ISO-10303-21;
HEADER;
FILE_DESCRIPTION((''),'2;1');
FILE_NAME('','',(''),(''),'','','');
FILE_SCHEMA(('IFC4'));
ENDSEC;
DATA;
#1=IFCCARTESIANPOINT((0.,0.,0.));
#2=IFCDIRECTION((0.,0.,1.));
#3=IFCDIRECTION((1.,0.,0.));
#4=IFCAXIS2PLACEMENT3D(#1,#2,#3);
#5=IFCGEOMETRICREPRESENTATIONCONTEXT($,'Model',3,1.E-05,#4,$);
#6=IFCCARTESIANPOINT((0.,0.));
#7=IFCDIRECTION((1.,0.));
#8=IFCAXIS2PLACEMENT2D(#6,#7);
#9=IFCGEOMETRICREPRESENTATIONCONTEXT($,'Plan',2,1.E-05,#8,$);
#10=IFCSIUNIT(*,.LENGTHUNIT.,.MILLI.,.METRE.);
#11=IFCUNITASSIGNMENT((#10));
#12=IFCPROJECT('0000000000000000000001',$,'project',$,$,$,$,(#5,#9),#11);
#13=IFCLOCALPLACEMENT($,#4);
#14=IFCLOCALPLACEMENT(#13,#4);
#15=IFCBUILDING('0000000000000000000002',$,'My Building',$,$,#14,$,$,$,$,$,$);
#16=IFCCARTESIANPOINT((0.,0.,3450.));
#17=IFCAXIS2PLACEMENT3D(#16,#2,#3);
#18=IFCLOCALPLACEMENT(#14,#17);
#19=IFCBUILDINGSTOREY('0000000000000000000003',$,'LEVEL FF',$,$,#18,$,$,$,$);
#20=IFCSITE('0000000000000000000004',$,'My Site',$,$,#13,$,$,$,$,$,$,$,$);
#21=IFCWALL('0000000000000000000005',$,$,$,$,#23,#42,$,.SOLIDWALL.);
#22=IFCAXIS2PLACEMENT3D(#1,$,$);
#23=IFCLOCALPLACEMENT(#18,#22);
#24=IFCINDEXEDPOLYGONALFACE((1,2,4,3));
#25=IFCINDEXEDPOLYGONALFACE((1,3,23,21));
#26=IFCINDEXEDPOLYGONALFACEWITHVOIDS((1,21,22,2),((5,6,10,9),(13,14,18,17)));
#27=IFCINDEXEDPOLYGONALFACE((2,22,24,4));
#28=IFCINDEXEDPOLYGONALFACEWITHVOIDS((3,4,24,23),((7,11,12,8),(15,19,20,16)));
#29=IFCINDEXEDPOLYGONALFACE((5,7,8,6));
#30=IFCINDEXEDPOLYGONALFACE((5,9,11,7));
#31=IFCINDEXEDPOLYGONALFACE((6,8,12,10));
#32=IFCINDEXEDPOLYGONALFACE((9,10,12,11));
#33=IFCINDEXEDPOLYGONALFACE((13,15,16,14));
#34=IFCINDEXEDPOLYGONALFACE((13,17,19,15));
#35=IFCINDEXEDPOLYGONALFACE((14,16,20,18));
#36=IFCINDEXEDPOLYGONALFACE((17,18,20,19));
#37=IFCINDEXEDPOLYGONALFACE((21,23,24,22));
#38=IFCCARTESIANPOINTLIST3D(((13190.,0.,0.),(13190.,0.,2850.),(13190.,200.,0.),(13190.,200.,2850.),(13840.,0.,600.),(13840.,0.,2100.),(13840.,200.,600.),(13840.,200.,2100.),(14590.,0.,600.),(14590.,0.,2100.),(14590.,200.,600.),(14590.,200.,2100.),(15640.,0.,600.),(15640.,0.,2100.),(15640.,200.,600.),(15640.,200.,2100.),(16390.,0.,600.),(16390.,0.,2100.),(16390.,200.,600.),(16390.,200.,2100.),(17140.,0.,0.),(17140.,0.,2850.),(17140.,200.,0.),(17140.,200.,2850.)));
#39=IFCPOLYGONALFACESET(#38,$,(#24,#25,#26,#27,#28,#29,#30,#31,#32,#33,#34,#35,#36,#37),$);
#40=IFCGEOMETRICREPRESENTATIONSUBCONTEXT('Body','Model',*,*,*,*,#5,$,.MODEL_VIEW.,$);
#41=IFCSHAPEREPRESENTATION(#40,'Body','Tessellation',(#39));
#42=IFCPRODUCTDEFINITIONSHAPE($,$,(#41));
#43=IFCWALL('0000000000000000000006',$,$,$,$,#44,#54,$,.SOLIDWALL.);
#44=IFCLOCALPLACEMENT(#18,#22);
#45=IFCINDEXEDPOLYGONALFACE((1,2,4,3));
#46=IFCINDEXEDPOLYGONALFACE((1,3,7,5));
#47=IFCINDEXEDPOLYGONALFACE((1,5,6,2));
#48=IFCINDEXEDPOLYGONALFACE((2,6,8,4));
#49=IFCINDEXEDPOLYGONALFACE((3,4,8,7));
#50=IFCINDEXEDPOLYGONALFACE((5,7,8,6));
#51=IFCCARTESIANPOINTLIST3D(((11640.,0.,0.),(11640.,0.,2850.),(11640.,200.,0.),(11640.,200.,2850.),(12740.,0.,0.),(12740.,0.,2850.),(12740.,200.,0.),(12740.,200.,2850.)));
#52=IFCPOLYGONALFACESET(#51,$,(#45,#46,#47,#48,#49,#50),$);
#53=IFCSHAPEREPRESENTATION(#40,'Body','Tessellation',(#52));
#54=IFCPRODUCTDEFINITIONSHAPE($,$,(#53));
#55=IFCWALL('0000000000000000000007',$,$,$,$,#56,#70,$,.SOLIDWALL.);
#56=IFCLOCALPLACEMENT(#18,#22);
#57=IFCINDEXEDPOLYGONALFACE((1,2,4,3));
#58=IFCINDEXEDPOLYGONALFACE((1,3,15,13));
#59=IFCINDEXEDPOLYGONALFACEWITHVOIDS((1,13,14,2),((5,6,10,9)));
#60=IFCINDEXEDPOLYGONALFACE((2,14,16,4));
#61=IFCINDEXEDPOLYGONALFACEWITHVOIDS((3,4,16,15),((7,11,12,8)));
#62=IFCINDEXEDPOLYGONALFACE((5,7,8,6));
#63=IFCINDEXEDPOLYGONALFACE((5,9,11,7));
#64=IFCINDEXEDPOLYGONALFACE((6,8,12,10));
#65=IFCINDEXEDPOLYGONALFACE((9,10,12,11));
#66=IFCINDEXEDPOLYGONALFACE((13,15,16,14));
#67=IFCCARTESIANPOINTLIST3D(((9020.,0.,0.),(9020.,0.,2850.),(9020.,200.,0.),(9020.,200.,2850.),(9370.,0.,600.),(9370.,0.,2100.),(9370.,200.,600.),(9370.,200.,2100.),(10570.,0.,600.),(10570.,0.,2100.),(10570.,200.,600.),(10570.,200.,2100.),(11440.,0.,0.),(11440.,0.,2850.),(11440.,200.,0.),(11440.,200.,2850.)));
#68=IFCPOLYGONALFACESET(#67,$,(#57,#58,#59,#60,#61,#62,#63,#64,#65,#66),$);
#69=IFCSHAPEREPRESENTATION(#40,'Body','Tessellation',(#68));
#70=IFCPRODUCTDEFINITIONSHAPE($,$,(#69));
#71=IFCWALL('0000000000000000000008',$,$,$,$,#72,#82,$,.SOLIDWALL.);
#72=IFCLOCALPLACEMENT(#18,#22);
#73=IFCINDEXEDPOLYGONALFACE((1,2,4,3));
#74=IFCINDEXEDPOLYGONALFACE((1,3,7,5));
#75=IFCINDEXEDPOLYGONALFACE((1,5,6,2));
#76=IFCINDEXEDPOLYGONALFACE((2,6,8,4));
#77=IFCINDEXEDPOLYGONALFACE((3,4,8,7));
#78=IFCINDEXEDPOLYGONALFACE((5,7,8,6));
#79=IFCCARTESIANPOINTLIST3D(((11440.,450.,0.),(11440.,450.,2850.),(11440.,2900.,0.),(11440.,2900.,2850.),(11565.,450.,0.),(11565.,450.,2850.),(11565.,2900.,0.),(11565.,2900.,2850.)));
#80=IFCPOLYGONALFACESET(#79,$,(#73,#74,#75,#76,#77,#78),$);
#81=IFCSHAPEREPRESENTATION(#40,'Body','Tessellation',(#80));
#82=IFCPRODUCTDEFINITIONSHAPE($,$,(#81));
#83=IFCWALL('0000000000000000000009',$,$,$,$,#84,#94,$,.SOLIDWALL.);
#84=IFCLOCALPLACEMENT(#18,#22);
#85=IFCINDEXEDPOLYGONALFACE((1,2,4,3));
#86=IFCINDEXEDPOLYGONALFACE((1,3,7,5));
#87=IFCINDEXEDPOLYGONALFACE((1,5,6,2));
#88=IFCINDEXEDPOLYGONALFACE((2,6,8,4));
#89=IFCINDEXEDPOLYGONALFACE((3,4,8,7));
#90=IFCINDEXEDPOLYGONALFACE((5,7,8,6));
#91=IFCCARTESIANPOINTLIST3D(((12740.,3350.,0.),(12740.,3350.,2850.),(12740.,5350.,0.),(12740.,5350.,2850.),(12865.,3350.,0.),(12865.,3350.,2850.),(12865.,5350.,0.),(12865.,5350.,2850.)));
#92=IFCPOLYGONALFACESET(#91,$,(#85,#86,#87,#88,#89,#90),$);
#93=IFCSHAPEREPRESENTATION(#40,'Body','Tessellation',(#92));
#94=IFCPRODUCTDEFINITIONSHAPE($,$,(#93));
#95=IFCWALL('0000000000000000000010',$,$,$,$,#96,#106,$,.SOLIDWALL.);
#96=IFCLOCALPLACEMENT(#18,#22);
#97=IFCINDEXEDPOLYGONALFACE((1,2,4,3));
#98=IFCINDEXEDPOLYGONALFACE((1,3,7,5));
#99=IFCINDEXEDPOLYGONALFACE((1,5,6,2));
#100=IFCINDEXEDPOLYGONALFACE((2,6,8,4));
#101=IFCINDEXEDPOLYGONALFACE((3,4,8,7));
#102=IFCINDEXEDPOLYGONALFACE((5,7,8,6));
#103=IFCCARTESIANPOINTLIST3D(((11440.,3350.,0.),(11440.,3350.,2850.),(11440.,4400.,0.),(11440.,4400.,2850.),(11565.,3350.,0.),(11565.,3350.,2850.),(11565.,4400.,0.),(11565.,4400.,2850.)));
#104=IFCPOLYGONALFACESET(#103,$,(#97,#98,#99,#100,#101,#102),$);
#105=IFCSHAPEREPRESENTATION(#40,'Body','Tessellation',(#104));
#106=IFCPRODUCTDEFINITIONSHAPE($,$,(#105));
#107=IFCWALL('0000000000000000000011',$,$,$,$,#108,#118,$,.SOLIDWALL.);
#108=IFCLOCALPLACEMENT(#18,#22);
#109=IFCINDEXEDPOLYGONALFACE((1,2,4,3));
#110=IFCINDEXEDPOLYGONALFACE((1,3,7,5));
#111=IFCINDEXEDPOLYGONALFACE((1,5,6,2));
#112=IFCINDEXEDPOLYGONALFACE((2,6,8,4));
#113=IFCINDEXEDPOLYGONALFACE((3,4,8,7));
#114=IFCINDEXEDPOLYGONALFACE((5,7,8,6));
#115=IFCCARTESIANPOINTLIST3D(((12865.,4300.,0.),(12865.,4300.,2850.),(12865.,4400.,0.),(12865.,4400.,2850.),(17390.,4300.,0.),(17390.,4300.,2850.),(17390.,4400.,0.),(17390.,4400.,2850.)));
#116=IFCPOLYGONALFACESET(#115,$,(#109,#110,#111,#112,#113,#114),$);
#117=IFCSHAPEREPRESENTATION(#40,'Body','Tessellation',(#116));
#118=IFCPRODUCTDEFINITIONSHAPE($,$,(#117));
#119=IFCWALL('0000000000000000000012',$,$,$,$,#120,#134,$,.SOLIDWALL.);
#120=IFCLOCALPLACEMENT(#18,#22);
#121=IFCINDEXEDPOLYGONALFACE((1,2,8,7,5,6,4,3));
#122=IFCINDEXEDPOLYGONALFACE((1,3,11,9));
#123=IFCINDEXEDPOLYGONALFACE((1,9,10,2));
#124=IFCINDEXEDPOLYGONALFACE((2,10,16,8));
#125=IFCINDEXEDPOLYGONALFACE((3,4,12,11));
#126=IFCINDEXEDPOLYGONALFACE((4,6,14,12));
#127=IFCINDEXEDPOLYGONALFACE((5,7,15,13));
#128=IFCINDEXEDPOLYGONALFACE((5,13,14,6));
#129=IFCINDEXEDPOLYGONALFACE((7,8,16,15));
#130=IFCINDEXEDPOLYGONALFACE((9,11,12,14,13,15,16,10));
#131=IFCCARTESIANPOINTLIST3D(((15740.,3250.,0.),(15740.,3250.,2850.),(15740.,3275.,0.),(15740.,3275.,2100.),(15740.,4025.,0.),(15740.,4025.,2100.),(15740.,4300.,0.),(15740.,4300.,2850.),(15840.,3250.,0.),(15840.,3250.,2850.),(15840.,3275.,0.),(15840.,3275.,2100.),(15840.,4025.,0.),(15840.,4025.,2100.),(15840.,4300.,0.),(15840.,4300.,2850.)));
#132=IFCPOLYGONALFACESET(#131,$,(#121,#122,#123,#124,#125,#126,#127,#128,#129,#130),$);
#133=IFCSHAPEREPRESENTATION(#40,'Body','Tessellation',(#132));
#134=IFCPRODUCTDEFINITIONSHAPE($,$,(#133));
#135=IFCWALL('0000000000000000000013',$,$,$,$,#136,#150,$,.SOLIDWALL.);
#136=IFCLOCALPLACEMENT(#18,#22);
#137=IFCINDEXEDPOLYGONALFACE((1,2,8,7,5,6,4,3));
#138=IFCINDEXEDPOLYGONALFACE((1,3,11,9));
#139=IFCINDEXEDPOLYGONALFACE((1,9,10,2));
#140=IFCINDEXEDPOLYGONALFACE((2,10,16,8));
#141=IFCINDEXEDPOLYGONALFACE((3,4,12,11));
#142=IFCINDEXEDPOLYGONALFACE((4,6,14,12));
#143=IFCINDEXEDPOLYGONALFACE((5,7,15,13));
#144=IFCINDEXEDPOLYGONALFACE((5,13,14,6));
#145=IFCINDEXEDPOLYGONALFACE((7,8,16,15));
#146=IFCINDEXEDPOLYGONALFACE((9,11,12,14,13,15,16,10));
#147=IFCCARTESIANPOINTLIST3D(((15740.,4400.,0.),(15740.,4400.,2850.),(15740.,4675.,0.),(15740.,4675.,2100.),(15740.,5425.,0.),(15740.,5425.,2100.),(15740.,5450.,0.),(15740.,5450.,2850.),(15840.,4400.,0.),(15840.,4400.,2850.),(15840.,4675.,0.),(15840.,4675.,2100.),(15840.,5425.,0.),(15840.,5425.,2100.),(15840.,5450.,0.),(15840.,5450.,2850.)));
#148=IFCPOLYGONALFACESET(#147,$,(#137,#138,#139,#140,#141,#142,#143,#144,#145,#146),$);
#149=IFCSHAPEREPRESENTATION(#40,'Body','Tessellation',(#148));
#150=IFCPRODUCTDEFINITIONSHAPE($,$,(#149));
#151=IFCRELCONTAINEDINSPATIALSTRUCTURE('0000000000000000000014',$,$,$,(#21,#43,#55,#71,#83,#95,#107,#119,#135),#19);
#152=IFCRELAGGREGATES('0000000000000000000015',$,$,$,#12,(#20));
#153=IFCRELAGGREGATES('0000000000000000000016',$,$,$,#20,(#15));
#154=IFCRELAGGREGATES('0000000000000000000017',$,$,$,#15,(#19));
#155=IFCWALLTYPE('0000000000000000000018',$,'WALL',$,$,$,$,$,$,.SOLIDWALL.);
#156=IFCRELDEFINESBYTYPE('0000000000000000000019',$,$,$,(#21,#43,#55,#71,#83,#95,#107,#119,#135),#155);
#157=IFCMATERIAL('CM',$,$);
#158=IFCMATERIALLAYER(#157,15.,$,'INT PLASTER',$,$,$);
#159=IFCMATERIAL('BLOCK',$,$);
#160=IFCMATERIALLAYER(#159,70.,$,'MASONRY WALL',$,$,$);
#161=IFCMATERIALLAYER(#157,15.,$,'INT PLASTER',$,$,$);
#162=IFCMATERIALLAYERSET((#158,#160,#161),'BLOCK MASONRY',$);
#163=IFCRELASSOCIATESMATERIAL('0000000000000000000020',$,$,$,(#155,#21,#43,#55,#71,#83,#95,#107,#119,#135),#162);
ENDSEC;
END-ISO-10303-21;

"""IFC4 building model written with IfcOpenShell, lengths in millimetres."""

from ifc_helpers import new_model, si_unit, frame, origin_with_axes, origin_2d_with_axis, place, context, subcontext, project, spatial, indexed_curve, outline, extrude, material, layer, layer_set, layer_usage, type_object, element, save


model = new_model("IFC4")

# Units and contexts
model_context = context("Model", 3, precision=1e-05, world=origin_with_axes())
plan_context = context("Plan", 2, precision=1e-05, world=origin_2d_with_axis())
body_context = subcontext(model_context, "Body", "Model", "MODEL_VIEW")
ifc_project = project(units=[si_unit("LENGTHUNIT", "METRE", prefix="MILLI")], contexts=[model_context, plan_context])

# Site, building, storey
site_placement = place(None, origin_with_axes())
site = spatial("IfcSite", under=ifc_project, at=site_placement, Name="My Site")
building_placement = place(site_placement, origin_with_axes())
building = spatial("IfcBuilding", under=site, at=building_placement, Name="My Building")
storey_placement = place(building_placement, frame((0.0, 0.0, 3450.0), z_axis=(0.0, 0.0, 1.0), x_axis=(1.0, 0.0, 0.0)))
storey = spatial("IfcBuildingStorey", under=building, at=storey_placement, Name="LEVEL FF")

# Shared definitions
ifc_material_1 = material(Name="CM")
ifc_layer_1 = layer(ifc_material_1, 15.0, Name="INT PLASTER")
ifc_material_2 = material(Name="BLOCK")
ifc_layer_2 = layer(ifc_material_2, 70.0, Name="MASONRY WALL")
ifc_layer_3 = layer(ifc_material_1, 15.0, Name="INT PLASTER")
ifc_layer_set = layer_set([ifc_layer_1, ifc_layer_2, ifc_layer_3], Name="BLOCK MASONRY")
wall_type = type_object("IfcWallType", Name="WALL", PredefinedType="SOLIDWALL", material=ifc_layer_set)

# Wall, openings
ifc_layer_usage_1 = layer_usage(ifc_layer_set, "AXIS2", "POSITIVE", 0.0)
wall_1_placement = place(storey_placement, frame((13190.0, 200.0, 0.0), z_axis=(0.0, 0.0, 1.0), x_axis=(0.0, -1.0, 0.0)))
wall_1 = element("IfcWall", 1, at=wall_1_placement, inside=storey, type_object=wall_type, material=ifc_layer_usage_1, PredefinedType="SOLIDWALL", context=body_context, shape_type="SweptSolid", body=[
    extrude(outline(indexed_curve([(0.0, 0.0), (0.0, 3950.0), (200.0, 3950.0), (200.0, 0.0), (0.0, 0.0)], self_intersect=False)), origin_with_axes(), (0.0, 0.0, 1.0), 2850.0),
])
opening_1_placement = place(wall_1_placement, frame((0.0, 1400.0, 600.0), z_axis=(0.0, 0.0, 1.0), x_axis=(0.0, -1.0, 0.0)))
element("IfcOpeningElement", 2, at=opening_1_placement, cuts=wall_1, PredefinedType="OPENING", context=body_context, shape_type="SweptSolid", body=[
    extrude(outline(indexed_curve([(0.0, 0.0), (0.0, 400.0), (750.0, 400.0), (750.0, 0.0), (0.0, 0.0)], self_intersect=False)), frame((0.0, -100.0, 0.0), z_axis=(0.0, 0.0, 1.0), x_axis=(1.0, 0.0, 0.0)), (0.0, 0.0, 1.0), 1500.0),
])
opening_2_placement = place(wall_1_placement, frame((0.0, 3200.0, 600.0), z_axis=(0.0, 0.0, 1.0), x_axis=(0.0, -1.0, 0.0)))
element("IfcOpeningElement", 3, at=opening_2_placement, cuts=wall_1, PredefinedType="OPENING", context=body_context, shape_type="SweptSolid", body=[
    extrude(outline(indexed_curve([(0.0, 0.0), (0.0, 400.0), (750.0, 400.0), (750.0, 0.0), (0.0, 0.0)], self_intersect=False)), frame((0.0, -100.0, 0.0), z_axis=(0.0, 0.0, 1.0), x_axis=(1.0, 0.0, 0.0)), (0.0, 0.0, 1.0), 1500.0),
])

# Wall
ifc_layer_usage_2 = layer_usage(ifc_layer_set, "AXIS2", "POSITIVE", 0.0)
wall_2_placement = place(storey_placement, frame((11640.0, 200.0, 0.0), z_axis=(0.0, 0.0, 1.0), x_axis=(0.0, -1.0, 0.0)))
element("IfcWall", 4, at=wall_2_placement, inside=storey, type_object=wall_type, material=ifc_layer_usage_2, PredefinedType="SOLIDWALL", context=body_context, shape_type="SweptSolid", body=[
    extrude(outline(indexed_curve([(0.0, 0.0), (0.0, 1100.0), (200.0, 1100.0), (200.0, 0.0), (0.0, 0.0)], self_intersect=False)), origin_with_axes(), (0.0, 0.0, 1.0), 2850.0),
])

# Wall, opening
ifc_layer_usage_3 = layer_usage(ifc_layer_set, "AXIS2", "POSITIVE", 0.0)
wall_3_placement = place(storey_placement, frame((9020.0, 200.0, 0.0), z_axis=(0.0, 0.0, 1.0), x_axis=(0.0, -1.0, 0.0)))
wall_3 = element("IfcWall", 5, at=wall_3_placement, inside=storey, type_object=wall_type, material=ifc_layer_usage_3, PredefinedType="SOLIDWALL", context=body_context, shape_type="SweptSolid", body=[
    extrude(outline(indexed_curve([(0.0, 0.0), (0.0, 2420.0), (200.0, 2420.0), (200.0, 0.0), (0.0, 0.0)], self_intersect=False)), origin_with_axes(), (0.0, 0.0, 1.0), 2850.0),
])
opening_3_placement = place(wall_3_placement, frame((0.0, 1550.0, 600.0), z_axis=(0.0, 0.0, 1.0), x_axis=(0.0, -1.0, 0.0)))
element("IfcOpeningElement", 6, at=opening_3_placement, cuts=wall_3, PredefinedType="OPENING", context=body_context, shape_type="SweptSolid", body=[
    extrude(outline(indexed_curve([(0.0, 0.0), (0.0, 400.0), (1200.0, 400.0), (1200.0, 0.0), (0.0, 0.0)], self_intersect=False)), frame((0.0, -100.0, 0.0), z_axis=(0.0, 0.0, 1.0), x_axis=(1.0, 0.0, 0.0)), (0.0, 0.0, 1.0), 1500.0),
])

# Wall
ifc_layer_usage_4 = layer_usage(ifc_layer_set, "AXIS2", "POSITIVE", 0.0)
wall_4_placement = place(storey_placement, frame((11565.0, 450.0, 0.0), z_axis=(0.0, 0.0, 1.0), x_axis=(0.0, 1.0, 0.0)))
element("IfcWall", 7, at=wall_4_placement, inside=storey, type_object=wall_type, material=ifc_layer_usage_4, PredefinedType="SOLIDWALL", context=body_context, shape_type="SweptSolid", body=[
    extrude(outline(indexed_curve([(0.0, 0.0), (0.0, 125.0), (2450.0, 125.0), (2450.0, 0.0), (0.0, 0.0)], self_intersect=False)), origin_with_axes(), (0.0, 0.0, 1.0), 2850.0),
])

# Walls
ifc_layer_usage_5 = layer_usage(ifc_layer_set, "AXIS2", "POSITIVE", 0.0)
wall_5_placement = place(storey_placement, frame((12865.0, 3350.0, 0.0), z_axis=(0.0, 0.0, 1.0), x_axis=(0.0, 1.0, 0.0)))
element("IfcWall", 8, at=wall_5_placement, inside=storey, type_object=wall_type, material=ifc_layer_usage_5, PredefinedType="SOLIDWALL", context=body_context, shape_type="SweptSolid", body=[
    extrude(outline(indexed_curve([(0.0, 0.0), (0.0, 125.0), (2000.0, 125.0), (2000.0, 0.0), (0.0, 0.0)], self_intersect=False)), origin_with_axes(), (0.0, 0.0, 1.0), 2850.0),
])
ifc_layer_usage_6 = layer_usage(ifc_layer_set, "AXIS2", "POSITIVE", 0.0)
wall_6_placement = place(storey_placement, frame((11565.0, 3350.0, 0.0), z_axis=(0.0, 0.0, 1.0), x_axis=(0.0, 1.0, 0.0)))
element("IfcWall", 9, at=wall_6_placement, inside=storey, type_object=wall_type, material=ifc_layer_usage_6, PredefinedType="SOLIDWALL", context=body_context, shape_type="SweptSolid", body=[
    extrude(outline(indexed_curve([(0.0, 0.0), (0.0, 125.0), (1050.0, 125.0), (1050.0, 0.0), (0.0, 0.0)], self_intersect=False)), origin_with_axes(), (0.0, 0.0, 1.0), 2850.0),
])
ifc_layer_usage_7 = layer_usage(ifc_layer_set, "AXIS2", "POSITIVE", 0.0)
wall_7_placement = place(storey_placement, frame((12865.0, 4400.0, 0.0), z_axis=(0.0, 0.0, 1.0), x_axis=(0.0, -1.0, 0.0)))
element("IfcWall", 10, at=wall_7_placement, inside=storey, type_object=wall_type, material=ifc_layer_usage_7, PredefinedType="SOLIDWALL", context=body_context, shape_type="SweptSolid", body=[
    extrude(outline(indexed_curve([(0.0, 0.0), (0.0, 4525.0), (100.0, 4525.0), (100.0, 0.0), (0.0, 0.0)], self_intersect=False)), origin_with_axes(), (0.0, 0.0, 1.0), 2850.0),
])

# Walls, openings
ifc_layer_usage_8 = layer_usage(ifc_layer_set, "AXIS2", "POSITIVE", 0.0)
wall_8_placement = place(storey_placement, frame((15840.0, 3250.0, 0.0), z_axis=(0.0, 0.0, 1.0), x_axis=(0.0, 1.0, 0.0)))
wall_8 = element("IfcWall", 11, at=wall_8_placement, inside=storey, type_object=wall_type, material=ifc_layer_usage_8, PredefinedType="SOLIDWALL", context=body_context, shape_type="SweptSolid", body=[
    extrude(outline(indexed_curve([(0.0, 0.0), (0.0, 100.0), (1050.0, 100.0), (1050.0, 0.0), (0.0, 0.0)], self_intersect=False)), origin_with_axes(), (0.0, 0.0, 1.0), 2850.0),
])
opening_4_placement = place(wall_8_placement, frame((775.0, 100.0, 0.0), z_axis=(0.0, 0.0, 1.0), x_axis=(-1.0, 0.0, 0.0)))
element("IfcOpeningElement", 12, at=opening_4_placement, cuts=wall_8, PredefinedType="OPENING", context=body_context, shape_type="SweptSolid", body=[
    extrude(outline(indexed_curve([(0.0, 0.0), (0.0, 400.0), (750.0, 400.0), (750.0, 0.0), (0.0, 0.0)], self_intersect=False)), frame((0.0, -100.0, 0.0), z_axis=(0.0, 0.0, 1.0), x_axis=(1.0, 0.0, 0.0)), (0.0, 0.0, 1.0), 2100.0),
])
ifc_layer_usage_9 = layer_usage(ifc_layer_set, "AXIS2", "POSITIVE", 0.0)
wall_9_placement = place(storey_placement, frame((15840.0, 4400.0, 0.0), z_axis=(0.0, 0.0, 1.0), x_axis=(0.0, 1.0, 0.0)))
wall_9 = element("IfcWall", 13, at=wall_9_placement, inside=storey, type_object=wall_type, material=ifc_layer_usage_9, PredefinedType="SOLIDWALL", context=body_context, shape_type="SweptSolid", body=[
    extrude(outline(indexed_curve([(0.0, 0.0), (0.0, 100.0), (1050.0, 100.0), (1050.0, 0.0), (0.0, 0.0)], self_intersect=False)), origin_with_axes(), (0.0, 0.0, 1.0), 2850.0),
])
opening_5_placement = place(wall_9_placement, frame((1025.0, 100.0, 0.0), z_axis=(0.0, 0.0, 1.0), x_axis=(-1.0, 0.0, 0.0)))
element("IfcOpeningElement", 14, at=opening_5_placement, cuts=wall_9, PredefinedType="OPENING", context=body_context, shape_type="SweptSolid", body=[
    extrude(outline(indexed_curve([(0.0, 0.0), (0.0, 400.0), (750.0, 400.0), (750.0, 0.0), (0.0, 0.0)], self_intersect=False)), frame((0.0, -100.0, 0.0), z_axis=(0.0, 0.0, 1.0), x_axis=(1.0, 0.0, 0.0)), (0.0, 0.0, 1.0), 2100.0),
])

save(model, "model.ifc")
